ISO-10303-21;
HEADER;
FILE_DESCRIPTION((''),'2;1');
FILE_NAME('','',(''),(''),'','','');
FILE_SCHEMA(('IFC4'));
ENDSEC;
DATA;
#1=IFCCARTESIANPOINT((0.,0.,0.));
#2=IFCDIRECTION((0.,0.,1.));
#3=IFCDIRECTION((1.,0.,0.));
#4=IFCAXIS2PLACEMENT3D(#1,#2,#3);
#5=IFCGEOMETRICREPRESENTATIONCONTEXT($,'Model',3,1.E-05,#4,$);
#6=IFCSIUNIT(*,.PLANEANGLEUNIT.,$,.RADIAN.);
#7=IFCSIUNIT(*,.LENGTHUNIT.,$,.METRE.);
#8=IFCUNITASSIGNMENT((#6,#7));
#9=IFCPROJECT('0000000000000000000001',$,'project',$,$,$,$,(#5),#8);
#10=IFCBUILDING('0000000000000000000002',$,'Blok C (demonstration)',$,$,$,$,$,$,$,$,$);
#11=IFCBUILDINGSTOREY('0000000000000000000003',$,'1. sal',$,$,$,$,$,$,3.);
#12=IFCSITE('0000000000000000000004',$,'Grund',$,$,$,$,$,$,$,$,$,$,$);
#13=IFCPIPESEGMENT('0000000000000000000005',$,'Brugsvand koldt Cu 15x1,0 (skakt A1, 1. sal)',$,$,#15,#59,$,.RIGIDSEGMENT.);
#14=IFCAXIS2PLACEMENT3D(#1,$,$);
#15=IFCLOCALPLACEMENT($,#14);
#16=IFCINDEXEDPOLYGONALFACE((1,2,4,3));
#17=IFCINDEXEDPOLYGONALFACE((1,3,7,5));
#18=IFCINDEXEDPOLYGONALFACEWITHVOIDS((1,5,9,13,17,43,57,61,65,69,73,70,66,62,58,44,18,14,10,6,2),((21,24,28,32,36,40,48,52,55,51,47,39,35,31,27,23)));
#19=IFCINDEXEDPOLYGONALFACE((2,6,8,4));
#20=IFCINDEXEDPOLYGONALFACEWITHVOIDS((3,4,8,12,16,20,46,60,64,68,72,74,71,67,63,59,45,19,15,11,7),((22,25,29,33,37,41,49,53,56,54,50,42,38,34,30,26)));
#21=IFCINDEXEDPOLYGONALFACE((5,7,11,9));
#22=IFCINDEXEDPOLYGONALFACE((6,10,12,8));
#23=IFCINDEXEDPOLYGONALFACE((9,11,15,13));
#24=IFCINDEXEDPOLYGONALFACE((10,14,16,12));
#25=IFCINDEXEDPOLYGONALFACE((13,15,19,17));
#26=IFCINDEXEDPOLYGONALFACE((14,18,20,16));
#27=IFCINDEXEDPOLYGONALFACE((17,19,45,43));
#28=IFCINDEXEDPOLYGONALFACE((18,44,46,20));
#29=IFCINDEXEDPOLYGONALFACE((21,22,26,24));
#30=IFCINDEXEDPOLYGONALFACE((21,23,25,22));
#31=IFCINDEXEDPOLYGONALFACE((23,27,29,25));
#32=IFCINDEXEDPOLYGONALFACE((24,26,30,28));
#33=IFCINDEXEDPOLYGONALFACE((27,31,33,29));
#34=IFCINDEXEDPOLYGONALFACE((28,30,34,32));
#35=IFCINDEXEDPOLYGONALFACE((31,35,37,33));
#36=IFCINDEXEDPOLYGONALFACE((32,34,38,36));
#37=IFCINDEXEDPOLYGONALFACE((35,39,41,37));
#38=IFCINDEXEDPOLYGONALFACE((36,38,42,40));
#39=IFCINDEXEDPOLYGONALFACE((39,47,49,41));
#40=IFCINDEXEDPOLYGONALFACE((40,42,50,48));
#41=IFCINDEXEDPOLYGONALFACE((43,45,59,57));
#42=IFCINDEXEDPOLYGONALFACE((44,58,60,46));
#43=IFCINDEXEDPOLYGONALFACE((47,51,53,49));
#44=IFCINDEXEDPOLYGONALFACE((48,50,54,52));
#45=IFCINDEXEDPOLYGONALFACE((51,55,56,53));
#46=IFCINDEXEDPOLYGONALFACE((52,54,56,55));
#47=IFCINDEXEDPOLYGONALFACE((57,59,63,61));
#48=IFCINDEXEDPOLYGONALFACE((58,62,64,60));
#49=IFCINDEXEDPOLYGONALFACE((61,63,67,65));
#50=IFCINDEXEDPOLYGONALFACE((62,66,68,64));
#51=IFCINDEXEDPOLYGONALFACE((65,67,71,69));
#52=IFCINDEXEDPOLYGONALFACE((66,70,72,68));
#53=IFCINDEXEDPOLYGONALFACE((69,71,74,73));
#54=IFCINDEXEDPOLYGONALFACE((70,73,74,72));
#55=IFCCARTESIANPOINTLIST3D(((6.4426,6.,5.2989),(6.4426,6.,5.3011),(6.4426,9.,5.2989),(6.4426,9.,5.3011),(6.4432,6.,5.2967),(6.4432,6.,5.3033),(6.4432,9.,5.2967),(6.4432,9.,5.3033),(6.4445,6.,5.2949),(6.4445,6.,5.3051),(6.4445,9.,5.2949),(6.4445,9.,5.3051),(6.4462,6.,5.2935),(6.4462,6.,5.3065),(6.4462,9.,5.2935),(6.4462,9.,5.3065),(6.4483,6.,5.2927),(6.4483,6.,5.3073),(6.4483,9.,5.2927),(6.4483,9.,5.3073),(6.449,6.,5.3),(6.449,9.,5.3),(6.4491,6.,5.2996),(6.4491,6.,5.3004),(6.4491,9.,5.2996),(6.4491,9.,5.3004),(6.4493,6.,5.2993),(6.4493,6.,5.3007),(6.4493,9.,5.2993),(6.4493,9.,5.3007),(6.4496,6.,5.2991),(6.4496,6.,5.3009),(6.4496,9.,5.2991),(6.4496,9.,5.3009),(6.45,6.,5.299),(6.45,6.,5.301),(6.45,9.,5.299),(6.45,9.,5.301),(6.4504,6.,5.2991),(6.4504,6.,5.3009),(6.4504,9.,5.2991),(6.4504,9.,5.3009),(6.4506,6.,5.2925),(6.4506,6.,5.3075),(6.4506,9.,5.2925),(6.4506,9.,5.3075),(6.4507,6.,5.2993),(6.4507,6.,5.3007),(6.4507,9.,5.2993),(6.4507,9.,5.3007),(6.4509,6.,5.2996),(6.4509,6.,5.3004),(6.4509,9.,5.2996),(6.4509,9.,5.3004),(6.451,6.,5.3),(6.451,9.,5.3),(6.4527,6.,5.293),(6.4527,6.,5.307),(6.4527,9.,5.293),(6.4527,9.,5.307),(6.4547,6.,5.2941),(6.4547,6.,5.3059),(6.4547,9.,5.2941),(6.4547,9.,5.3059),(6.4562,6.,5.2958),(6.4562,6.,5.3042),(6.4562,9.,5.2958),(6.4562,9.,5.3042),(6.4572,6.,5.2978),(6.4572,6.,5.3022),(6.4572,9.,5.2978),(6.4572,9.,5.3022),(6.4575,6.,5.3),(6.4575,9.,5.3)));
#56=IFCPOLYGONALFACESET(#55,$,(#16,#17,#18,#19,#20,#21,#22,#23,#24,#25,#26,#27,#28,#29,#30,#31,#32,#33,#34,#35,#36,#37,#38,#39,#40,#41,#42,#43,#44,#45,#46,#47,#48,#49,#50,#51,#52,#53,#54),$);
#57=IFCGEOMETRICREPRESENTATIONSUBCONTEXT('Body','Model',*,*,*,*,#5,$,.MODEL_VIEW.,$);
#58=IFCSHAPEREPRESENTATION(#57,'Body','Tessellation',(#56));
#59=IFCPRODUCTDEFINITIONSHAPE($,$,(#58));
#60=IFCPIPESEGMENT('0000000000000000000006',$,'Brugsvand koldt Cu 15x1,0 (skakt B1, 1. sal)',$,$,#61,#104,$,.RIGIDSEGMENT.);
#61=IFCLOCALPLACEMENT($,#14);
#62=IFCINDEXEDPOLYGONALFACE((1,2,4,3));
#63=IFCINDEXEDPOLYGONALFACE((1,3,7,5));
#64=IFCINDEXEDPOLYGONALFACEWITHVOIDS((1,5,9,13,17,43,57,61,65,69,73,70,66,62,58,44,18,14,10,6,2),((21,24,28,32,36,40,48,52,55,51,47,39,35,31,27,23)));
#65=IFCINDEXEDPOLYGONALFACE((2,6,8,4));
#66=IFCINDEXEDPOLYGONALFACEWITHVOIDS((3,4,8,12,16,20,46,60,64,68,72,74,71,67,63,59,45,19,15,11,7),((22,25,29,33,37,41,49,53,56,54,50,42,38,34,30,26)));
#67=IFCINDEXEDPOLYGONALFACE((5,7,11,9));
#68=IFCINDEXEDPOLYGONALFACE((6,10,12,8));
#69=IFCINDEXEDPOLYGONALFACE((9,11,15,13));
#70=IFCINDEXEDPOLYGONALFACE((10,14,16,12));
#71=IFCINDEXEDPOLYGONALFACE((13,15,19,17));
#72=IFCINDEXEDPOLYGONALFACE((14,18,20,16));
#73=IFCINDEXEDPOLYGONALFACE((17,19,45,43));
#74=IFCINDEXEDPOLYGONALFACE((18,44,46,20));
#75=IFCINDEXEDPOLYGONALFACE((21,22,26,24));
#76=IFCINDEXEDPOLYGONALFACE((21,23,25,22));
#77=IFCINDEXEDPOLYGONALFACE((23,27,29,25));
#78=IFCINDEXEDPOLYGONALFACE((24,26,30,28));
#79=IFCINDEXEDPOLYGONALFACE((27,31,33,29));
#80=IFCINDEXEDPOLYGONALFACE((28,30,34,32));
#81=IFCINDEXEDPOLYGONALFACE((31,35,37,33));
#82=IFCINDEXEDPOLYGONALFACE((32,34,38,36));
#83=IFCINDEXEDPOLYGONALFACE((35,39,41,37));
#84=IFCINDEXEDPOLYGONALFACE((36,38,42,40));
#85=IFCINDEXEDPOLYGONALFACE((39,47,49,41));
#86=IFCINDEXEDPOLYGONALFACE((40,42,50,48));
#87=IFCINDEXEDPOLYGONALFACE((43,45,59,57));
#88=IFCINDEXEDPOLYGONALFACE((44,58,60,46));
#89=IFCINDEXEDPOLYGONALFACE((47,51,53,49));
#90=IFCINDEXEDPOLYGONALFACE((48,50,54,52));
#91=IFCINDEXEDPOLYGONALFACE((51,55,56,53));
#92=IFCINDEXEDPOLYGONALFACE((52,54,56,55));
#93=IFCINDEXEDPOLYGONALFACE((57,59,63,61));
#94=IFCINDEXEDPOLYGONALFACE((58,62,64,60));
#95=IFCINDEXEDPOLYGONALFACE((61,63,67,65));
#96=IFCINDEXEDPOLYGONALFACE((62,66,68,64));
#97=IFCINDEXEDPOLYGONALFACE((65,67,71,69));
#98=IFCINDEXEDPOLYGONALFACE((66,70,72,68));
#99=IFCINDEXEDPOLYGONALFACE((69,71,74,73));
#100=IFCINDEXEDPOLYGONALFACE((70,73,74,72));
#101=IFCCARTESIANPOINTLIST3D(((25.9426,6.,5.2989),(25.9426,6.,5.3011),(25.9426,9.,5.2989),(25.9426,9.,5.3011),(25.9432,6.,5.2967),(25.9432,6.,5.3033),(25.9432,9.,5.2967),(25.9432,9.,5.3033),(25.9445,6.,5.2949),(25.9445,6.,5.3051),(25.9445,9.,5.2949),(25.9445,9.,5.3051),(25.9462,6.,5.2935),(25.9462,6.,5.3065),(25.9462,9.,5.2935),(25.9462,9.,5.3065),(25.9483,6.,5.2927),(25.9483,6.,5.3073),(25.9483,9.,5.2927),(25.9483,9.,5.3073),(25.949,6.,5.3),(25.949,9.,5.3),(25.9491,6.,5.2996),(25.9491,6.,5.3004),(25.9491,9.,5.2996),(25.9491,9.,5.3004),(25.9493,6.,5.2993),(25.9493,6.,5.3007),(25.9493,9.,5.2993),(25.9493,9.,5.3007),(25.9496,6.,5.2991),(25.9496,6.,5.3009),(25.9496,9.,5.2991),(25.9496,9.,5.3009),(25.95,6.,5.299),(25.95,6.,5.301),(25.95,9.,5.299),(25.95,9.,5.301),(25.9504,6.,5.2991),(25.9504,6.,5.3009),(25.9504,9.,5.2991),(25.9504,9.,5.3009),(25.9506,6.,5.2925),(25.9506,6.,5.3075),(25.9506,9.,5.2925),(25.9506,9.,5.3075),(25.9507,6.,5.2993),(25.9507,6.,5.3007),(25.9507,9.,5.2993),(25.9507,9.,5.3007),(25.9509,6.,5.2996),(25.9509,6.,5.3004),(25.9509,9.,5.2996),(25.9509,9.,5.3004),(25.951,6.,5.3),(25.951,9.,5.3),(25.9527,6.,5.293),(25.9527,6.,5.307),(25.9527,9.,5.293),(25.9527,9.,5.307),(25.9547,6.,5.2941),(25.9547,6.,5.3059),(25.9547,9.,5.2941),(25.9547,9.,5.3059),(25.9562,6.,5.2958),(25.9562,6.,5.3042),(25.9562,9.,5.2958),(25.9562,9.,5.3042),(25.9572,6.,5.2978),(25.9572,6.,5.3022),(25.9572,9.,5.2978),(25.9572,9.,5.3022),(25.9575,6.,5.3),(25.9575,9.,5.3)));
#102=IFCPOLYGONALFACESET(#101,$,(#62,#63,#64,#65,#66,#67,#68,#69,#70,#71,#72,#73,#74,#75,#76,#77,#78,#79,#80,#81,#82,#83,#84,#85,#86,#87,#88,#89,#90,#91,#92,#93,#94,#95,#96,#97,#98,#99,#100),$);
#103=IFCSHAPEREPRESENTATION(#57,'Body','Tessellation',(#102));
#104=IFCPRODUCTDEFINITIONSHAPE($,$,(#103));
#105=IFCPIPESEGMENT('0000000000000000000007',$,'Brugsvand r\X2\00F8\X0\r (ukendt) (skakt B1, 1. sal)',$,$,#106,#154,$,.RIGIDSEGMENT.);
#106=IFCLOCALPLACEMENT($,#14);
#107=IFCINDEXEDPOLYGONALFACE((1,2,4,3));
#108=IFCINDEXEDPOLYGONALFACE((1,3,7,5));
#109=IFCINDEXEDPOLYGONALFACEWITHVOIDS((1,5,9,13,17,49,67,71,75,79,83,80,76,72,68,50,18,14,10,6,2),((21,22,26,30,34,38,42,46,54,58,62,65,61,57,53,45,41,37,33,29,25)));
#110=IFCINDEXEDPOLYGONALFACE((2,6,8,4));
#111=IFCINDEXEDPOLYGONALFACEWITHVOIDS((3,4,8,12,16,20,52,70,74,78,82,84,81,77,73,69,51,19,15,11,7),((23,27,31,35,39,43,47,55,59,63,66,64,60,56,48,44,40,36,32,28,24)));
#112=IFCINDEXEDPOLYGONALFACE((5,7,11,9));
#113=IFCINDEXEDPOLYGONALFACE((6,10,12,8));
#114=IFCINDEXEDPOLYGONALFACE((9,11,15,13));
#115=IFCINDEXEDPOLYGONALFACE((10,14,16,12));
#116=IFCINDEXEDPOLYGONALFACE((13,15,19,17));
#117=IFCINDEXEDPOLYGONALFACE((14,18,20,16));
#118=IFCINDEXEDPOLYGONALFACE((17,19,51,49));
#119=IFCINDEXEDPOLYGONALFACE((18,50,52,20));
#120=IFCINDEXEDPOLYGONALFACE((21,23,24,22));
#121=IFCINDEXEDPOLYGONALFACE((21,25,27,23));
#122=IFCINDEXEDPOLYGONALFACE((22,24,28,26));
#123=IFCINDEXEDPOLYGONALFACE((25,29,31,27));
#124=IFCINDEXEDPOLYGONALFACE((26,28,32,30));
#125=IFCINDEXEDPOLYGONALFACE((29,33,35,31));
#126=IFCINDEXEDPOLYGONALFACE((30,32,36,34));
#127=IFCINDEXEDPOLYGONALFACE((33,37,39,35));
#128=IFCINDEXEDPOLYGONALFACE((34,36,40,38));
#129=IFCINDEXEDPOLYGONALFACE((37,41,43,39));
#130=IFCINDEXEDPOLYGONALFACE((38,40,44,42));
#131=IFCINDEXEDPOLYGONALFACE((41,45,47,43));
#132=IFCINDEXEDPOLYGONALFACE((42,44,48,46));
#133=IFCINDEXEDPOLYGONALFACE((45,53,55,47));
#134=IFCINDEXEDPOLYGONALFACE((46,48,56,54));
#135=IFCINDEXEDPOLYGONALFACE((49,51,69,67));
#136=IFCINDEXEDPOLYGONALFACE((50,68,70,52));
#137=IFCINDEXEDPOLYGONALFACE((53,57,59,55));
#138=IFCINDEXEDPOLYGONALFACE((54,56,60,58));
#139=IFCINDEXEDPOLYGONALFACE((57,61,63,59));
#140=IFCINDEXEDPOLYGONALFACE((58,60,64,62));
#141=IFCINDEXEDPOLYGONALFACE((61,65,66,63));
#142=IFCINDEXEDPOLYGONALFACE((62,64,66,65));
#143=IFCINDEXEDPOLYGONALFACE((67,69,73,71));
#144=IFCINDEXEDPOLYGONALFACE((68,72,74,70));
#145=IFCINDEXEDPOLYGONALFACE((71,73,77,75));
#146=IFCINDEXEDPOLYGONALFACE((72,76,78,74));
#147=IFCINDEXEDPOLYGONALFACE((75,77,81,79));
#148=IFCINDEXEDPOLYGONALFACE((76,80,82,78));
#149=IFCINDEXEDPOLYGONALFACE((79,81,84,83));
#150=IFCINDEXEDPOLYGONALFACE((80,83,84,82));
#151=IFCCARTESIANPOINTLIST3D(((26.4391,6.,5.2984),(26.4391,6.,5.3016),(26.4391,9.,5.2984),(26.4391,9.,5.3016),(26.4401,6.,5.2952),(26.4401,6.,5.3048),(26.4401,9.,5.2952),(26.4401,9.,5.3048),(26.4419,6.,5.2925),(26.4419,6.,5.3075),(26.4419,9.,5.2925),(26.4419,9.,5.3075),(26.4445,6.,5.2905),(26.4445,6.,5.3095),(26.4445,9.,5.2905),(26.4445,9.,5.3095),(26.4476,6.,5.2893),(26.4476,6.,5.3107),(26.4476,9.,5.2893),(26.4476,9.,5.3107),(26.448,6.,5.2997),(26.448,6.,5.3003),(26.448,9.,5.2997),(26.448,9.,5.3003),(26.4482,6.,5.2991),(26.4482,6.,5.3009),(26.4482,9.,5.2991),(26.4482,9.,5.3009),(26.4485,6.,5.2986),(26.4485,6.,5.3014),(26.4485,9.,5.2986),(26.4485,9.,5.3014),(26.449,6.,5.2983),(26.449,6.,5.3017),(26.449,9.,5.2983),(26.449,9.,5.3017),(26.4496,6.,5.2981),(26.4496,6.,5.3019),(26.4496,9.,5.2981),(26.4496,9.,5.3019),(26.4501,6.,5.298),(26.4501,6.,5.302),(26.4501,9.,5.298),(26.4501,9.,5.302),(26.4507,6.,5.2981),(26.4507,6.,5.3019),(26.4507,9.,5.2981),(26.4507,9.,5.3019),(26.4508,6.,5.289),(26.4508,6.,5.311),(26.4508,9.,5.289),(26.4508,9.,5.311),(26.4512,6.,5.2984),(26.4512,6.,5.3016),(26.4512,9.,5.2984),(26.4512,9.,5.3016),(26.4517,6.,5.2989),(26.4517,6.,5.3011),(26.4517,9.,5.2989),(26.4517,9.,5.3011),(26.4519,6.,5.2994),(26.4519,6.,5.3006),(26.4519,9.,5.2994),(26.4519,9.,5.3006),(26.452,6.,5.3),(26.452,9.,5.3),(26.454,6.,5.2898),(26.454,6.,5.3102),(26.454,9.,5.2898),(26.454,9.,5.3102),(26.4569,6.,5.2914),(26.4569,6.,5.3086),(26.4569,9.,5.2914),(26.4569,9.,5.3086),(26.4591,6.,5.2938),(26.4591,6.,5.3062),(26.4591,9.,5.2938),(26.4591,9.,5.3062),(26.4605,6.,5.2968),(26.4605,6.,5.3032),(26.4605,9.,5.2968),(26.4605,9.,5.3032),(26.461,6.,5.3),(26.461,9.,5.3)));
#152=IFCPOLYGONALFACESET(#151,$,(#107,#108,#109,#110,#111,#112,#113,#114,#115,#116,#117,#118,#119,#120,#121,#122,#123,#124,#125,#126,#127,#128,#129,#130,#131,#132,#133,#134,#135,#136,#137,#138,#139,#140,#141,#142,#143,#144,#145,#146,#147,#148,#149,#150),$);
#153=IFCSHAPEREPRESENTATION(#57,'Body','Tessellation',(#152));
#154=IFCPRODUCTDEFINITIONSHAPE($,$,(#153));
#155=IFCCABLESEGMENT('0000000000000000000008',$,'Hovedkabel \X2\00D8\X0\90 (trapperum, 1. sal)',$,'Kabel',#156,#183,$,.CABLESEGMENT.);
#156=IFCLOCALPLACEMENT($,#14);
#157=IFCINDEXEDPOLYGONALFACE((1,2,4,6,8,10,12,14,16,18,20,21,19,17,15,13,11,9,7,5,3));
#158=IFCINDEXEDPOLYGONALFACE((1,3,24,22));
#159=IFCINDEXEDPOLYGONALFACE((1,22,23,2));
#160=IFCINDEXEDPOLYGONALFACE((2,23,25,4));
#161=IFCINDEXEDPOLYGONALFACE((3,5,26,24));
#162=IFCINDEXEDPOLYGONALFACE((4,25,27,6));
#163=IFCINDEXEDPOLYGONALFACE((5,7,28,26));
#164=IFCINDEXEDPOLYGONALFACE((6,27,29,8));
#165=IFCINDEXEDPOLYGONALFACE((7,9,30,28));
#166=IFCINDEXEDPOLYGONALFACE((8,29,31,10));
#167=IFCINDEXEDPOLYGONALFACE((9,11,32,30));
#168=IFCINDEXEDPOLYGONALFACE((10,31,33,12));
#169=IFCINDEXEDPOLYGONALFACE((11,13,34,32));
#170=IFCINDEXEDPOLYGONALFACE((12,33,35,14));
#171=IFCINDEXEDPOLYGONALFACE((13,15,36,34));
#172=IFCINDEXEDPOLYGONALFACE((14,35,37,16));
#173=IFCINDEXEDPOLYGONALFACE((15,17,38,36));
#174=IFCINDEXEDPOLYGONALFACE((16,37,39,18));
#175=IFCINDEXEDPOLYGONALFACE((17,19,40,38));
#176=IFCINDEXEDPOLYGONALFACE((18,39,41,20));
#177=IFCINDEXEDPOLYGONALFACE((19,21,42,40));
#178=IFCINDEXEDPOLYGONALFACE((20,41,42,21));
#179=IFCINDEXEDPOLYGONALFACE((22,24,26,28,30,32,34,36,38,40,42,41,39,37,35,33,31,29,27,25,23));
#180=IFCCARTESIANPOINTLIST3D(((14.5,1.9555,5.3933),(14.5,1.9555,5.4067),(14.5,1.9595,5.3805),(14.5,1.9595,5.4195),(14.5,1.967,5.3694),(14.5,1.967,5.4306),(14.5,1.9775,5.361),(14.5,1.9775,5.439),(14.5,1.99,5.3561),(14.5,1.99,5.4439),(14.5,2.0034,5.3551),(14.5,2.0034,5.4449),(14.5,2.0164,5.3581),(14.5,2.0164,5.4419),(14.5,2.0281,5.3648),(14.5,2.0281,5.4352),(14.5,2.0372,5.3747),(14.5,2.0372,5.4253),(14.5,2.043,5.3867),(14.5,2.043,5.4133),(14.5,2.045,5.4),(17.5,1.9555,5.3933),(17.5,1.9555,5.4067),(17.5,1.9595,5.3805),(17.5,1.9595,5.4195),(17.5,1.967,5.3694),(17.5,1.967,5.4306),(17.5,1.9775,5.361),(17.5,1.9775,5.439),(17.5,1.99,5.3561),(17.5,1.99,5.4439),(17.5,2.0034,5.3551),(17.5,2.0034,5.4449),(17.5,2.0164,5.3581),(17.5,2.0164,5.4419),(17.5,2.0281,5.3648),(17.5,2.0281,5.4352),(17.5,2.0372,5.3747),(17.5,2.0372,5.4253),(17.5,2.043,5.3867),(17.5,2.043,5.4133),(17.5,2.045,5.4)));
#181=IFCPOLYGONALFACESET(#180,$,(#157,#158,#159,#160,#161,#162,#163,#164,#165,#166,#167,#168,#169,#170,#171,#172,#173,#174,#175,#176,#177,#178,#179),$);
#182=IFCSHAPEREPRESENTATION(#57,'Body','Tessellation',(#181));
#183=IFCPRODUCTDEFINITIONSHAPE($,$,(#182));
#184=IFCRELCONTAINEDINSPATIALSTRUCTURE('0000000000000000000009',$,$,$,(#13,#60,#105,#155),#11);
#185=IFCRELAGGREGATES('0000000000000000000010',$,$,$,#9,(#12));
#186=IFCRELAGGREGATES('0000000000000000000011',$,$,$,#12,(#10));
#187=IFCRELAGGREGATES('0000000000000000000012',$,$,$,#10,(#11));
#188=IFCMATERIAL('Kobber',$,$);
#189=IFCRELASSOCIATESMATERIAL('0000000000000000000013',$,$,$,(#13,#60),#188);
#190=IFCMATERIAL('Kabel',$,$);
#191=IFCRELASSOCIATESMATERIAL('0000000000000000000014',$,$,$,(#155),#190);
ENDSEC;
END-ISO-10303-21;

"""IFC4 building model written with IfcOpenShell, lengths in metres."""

from ifc_helpers import new_model, si_unit, frame, origin_with_axes, place, context, subcontext, project, spatial, circle, hollow_circle, extrude, material, element, save


model = new_model("IFC4")

# Units and contexts
model_context = context("Model", 3, precision=1e-05, world=origin_with_axes())
body_context = subcontext(model_context, "Body", "Model", "MODEL_VIEW")
ifc_project = project(units=[si_unit("PLANEANGLEUNIT", "RADIAN"), si_unit("LENGTHUNIT", "METRE")], contexts=[model_context])

# Site, building, storey
site = spatial("IfcSite", under=ifc_project, Name="Grund")
building = spatial("IfcBuilding", under=site, Name="Blok C (demonstration)")
storey = spatial("IfcBuildingStorey", under=building, Name="1. sal", Elevation=3.0)

# Pipe segments
ifc_material_1 = material(Name="Kobber")
pipe_segment_1_placement = place(None, origin_with_axes())
element("IfcPipeSegment", 1, at=pipe_segment_1_placement, inside=storey, material=ifc_material_1, Name="Brugsvand koldt Cu 15x1,0 (skakt A1, 1. sal)", PredefinedType="RIGIDSEGMENT", context=body_context, shape_type="SweptSolid", body=[
    extrude(hollow_circle(Radius=0.0075, WallThickness=0.0065), frame((6.45, 6.0, 5.3), z_axis=(0.0, 1.0, 0.0), x_axis=(1.0, 0.0, 0.0)), (0.0, 0.0, 1.0), 3.0),
])
pipe_segment_2_placement = place(None, origin_with_axes())
element("IfcPipeSegment", 2, at=pipe_segment_2_placement, inside=storey, material=ifc_material_1, Name="Brugsvand koldt Cu 15x1,0 (skakt B1, 1. sal)", PredefinedType="RIGIDSEGMENT", context=body_context, shape_type="SweptSolid", body=[
    extrude(hollow_circle(Radius=0.0075, WallThickness=0.0065), frame((25.95, 6.0, 5.3), z_axis=(0.0, 1.0, 0.0), x_axis=(1.0, 0.0, 0.0)), (0.0, 0.0, 1.0), 3.0),
])
pipe_segment_3_placement = place(None, origin_with_axes())
element("IfcPipeSegment", 3, at=pipe_segment_3_placement, inside=storey, Name="Brugsvand rør (ukendt) (skakt B1, 1. sal)", PredefinedType="RIGIDSEGMENT", context=body_context, shape_type="SweptSolid", body=[
    extrude(hollow_circle(Radius=0.011, WallThickness=0.009), frame((26.45, 6.0, 5.3), z_axis=(0.0, 1.0, 0.0), x_axis=(1.0, 0.0, 0.0)), (0.0, 0.0, 1.0), 3.0),
])

# Cable segment
ifc_material_2 = material(Name="Kabel")
cable_segment_placement = place(None, origin_with_axes())
element("IfcCableSegment", 4, at=cable_segment_placement, inside=storey, material=ifc_material_2, Name="Hovedkabel Ø90 (trapperum, 1. sal)", ObjectType="Kabel", PredefinedType="CABLESEGMENT", context=body_context, shape_type="SweptSolid", body=[
    extrude(circle(Radius=0.045), frame((14.5, 2.0, 5.4), z_axis=(1.0, 0.0, 0.0), x_axis=(0.0, 1.0, 0.0)), (0.0, 0.0, 1.0), 3.0),
])

save(model, "model.ifc")
